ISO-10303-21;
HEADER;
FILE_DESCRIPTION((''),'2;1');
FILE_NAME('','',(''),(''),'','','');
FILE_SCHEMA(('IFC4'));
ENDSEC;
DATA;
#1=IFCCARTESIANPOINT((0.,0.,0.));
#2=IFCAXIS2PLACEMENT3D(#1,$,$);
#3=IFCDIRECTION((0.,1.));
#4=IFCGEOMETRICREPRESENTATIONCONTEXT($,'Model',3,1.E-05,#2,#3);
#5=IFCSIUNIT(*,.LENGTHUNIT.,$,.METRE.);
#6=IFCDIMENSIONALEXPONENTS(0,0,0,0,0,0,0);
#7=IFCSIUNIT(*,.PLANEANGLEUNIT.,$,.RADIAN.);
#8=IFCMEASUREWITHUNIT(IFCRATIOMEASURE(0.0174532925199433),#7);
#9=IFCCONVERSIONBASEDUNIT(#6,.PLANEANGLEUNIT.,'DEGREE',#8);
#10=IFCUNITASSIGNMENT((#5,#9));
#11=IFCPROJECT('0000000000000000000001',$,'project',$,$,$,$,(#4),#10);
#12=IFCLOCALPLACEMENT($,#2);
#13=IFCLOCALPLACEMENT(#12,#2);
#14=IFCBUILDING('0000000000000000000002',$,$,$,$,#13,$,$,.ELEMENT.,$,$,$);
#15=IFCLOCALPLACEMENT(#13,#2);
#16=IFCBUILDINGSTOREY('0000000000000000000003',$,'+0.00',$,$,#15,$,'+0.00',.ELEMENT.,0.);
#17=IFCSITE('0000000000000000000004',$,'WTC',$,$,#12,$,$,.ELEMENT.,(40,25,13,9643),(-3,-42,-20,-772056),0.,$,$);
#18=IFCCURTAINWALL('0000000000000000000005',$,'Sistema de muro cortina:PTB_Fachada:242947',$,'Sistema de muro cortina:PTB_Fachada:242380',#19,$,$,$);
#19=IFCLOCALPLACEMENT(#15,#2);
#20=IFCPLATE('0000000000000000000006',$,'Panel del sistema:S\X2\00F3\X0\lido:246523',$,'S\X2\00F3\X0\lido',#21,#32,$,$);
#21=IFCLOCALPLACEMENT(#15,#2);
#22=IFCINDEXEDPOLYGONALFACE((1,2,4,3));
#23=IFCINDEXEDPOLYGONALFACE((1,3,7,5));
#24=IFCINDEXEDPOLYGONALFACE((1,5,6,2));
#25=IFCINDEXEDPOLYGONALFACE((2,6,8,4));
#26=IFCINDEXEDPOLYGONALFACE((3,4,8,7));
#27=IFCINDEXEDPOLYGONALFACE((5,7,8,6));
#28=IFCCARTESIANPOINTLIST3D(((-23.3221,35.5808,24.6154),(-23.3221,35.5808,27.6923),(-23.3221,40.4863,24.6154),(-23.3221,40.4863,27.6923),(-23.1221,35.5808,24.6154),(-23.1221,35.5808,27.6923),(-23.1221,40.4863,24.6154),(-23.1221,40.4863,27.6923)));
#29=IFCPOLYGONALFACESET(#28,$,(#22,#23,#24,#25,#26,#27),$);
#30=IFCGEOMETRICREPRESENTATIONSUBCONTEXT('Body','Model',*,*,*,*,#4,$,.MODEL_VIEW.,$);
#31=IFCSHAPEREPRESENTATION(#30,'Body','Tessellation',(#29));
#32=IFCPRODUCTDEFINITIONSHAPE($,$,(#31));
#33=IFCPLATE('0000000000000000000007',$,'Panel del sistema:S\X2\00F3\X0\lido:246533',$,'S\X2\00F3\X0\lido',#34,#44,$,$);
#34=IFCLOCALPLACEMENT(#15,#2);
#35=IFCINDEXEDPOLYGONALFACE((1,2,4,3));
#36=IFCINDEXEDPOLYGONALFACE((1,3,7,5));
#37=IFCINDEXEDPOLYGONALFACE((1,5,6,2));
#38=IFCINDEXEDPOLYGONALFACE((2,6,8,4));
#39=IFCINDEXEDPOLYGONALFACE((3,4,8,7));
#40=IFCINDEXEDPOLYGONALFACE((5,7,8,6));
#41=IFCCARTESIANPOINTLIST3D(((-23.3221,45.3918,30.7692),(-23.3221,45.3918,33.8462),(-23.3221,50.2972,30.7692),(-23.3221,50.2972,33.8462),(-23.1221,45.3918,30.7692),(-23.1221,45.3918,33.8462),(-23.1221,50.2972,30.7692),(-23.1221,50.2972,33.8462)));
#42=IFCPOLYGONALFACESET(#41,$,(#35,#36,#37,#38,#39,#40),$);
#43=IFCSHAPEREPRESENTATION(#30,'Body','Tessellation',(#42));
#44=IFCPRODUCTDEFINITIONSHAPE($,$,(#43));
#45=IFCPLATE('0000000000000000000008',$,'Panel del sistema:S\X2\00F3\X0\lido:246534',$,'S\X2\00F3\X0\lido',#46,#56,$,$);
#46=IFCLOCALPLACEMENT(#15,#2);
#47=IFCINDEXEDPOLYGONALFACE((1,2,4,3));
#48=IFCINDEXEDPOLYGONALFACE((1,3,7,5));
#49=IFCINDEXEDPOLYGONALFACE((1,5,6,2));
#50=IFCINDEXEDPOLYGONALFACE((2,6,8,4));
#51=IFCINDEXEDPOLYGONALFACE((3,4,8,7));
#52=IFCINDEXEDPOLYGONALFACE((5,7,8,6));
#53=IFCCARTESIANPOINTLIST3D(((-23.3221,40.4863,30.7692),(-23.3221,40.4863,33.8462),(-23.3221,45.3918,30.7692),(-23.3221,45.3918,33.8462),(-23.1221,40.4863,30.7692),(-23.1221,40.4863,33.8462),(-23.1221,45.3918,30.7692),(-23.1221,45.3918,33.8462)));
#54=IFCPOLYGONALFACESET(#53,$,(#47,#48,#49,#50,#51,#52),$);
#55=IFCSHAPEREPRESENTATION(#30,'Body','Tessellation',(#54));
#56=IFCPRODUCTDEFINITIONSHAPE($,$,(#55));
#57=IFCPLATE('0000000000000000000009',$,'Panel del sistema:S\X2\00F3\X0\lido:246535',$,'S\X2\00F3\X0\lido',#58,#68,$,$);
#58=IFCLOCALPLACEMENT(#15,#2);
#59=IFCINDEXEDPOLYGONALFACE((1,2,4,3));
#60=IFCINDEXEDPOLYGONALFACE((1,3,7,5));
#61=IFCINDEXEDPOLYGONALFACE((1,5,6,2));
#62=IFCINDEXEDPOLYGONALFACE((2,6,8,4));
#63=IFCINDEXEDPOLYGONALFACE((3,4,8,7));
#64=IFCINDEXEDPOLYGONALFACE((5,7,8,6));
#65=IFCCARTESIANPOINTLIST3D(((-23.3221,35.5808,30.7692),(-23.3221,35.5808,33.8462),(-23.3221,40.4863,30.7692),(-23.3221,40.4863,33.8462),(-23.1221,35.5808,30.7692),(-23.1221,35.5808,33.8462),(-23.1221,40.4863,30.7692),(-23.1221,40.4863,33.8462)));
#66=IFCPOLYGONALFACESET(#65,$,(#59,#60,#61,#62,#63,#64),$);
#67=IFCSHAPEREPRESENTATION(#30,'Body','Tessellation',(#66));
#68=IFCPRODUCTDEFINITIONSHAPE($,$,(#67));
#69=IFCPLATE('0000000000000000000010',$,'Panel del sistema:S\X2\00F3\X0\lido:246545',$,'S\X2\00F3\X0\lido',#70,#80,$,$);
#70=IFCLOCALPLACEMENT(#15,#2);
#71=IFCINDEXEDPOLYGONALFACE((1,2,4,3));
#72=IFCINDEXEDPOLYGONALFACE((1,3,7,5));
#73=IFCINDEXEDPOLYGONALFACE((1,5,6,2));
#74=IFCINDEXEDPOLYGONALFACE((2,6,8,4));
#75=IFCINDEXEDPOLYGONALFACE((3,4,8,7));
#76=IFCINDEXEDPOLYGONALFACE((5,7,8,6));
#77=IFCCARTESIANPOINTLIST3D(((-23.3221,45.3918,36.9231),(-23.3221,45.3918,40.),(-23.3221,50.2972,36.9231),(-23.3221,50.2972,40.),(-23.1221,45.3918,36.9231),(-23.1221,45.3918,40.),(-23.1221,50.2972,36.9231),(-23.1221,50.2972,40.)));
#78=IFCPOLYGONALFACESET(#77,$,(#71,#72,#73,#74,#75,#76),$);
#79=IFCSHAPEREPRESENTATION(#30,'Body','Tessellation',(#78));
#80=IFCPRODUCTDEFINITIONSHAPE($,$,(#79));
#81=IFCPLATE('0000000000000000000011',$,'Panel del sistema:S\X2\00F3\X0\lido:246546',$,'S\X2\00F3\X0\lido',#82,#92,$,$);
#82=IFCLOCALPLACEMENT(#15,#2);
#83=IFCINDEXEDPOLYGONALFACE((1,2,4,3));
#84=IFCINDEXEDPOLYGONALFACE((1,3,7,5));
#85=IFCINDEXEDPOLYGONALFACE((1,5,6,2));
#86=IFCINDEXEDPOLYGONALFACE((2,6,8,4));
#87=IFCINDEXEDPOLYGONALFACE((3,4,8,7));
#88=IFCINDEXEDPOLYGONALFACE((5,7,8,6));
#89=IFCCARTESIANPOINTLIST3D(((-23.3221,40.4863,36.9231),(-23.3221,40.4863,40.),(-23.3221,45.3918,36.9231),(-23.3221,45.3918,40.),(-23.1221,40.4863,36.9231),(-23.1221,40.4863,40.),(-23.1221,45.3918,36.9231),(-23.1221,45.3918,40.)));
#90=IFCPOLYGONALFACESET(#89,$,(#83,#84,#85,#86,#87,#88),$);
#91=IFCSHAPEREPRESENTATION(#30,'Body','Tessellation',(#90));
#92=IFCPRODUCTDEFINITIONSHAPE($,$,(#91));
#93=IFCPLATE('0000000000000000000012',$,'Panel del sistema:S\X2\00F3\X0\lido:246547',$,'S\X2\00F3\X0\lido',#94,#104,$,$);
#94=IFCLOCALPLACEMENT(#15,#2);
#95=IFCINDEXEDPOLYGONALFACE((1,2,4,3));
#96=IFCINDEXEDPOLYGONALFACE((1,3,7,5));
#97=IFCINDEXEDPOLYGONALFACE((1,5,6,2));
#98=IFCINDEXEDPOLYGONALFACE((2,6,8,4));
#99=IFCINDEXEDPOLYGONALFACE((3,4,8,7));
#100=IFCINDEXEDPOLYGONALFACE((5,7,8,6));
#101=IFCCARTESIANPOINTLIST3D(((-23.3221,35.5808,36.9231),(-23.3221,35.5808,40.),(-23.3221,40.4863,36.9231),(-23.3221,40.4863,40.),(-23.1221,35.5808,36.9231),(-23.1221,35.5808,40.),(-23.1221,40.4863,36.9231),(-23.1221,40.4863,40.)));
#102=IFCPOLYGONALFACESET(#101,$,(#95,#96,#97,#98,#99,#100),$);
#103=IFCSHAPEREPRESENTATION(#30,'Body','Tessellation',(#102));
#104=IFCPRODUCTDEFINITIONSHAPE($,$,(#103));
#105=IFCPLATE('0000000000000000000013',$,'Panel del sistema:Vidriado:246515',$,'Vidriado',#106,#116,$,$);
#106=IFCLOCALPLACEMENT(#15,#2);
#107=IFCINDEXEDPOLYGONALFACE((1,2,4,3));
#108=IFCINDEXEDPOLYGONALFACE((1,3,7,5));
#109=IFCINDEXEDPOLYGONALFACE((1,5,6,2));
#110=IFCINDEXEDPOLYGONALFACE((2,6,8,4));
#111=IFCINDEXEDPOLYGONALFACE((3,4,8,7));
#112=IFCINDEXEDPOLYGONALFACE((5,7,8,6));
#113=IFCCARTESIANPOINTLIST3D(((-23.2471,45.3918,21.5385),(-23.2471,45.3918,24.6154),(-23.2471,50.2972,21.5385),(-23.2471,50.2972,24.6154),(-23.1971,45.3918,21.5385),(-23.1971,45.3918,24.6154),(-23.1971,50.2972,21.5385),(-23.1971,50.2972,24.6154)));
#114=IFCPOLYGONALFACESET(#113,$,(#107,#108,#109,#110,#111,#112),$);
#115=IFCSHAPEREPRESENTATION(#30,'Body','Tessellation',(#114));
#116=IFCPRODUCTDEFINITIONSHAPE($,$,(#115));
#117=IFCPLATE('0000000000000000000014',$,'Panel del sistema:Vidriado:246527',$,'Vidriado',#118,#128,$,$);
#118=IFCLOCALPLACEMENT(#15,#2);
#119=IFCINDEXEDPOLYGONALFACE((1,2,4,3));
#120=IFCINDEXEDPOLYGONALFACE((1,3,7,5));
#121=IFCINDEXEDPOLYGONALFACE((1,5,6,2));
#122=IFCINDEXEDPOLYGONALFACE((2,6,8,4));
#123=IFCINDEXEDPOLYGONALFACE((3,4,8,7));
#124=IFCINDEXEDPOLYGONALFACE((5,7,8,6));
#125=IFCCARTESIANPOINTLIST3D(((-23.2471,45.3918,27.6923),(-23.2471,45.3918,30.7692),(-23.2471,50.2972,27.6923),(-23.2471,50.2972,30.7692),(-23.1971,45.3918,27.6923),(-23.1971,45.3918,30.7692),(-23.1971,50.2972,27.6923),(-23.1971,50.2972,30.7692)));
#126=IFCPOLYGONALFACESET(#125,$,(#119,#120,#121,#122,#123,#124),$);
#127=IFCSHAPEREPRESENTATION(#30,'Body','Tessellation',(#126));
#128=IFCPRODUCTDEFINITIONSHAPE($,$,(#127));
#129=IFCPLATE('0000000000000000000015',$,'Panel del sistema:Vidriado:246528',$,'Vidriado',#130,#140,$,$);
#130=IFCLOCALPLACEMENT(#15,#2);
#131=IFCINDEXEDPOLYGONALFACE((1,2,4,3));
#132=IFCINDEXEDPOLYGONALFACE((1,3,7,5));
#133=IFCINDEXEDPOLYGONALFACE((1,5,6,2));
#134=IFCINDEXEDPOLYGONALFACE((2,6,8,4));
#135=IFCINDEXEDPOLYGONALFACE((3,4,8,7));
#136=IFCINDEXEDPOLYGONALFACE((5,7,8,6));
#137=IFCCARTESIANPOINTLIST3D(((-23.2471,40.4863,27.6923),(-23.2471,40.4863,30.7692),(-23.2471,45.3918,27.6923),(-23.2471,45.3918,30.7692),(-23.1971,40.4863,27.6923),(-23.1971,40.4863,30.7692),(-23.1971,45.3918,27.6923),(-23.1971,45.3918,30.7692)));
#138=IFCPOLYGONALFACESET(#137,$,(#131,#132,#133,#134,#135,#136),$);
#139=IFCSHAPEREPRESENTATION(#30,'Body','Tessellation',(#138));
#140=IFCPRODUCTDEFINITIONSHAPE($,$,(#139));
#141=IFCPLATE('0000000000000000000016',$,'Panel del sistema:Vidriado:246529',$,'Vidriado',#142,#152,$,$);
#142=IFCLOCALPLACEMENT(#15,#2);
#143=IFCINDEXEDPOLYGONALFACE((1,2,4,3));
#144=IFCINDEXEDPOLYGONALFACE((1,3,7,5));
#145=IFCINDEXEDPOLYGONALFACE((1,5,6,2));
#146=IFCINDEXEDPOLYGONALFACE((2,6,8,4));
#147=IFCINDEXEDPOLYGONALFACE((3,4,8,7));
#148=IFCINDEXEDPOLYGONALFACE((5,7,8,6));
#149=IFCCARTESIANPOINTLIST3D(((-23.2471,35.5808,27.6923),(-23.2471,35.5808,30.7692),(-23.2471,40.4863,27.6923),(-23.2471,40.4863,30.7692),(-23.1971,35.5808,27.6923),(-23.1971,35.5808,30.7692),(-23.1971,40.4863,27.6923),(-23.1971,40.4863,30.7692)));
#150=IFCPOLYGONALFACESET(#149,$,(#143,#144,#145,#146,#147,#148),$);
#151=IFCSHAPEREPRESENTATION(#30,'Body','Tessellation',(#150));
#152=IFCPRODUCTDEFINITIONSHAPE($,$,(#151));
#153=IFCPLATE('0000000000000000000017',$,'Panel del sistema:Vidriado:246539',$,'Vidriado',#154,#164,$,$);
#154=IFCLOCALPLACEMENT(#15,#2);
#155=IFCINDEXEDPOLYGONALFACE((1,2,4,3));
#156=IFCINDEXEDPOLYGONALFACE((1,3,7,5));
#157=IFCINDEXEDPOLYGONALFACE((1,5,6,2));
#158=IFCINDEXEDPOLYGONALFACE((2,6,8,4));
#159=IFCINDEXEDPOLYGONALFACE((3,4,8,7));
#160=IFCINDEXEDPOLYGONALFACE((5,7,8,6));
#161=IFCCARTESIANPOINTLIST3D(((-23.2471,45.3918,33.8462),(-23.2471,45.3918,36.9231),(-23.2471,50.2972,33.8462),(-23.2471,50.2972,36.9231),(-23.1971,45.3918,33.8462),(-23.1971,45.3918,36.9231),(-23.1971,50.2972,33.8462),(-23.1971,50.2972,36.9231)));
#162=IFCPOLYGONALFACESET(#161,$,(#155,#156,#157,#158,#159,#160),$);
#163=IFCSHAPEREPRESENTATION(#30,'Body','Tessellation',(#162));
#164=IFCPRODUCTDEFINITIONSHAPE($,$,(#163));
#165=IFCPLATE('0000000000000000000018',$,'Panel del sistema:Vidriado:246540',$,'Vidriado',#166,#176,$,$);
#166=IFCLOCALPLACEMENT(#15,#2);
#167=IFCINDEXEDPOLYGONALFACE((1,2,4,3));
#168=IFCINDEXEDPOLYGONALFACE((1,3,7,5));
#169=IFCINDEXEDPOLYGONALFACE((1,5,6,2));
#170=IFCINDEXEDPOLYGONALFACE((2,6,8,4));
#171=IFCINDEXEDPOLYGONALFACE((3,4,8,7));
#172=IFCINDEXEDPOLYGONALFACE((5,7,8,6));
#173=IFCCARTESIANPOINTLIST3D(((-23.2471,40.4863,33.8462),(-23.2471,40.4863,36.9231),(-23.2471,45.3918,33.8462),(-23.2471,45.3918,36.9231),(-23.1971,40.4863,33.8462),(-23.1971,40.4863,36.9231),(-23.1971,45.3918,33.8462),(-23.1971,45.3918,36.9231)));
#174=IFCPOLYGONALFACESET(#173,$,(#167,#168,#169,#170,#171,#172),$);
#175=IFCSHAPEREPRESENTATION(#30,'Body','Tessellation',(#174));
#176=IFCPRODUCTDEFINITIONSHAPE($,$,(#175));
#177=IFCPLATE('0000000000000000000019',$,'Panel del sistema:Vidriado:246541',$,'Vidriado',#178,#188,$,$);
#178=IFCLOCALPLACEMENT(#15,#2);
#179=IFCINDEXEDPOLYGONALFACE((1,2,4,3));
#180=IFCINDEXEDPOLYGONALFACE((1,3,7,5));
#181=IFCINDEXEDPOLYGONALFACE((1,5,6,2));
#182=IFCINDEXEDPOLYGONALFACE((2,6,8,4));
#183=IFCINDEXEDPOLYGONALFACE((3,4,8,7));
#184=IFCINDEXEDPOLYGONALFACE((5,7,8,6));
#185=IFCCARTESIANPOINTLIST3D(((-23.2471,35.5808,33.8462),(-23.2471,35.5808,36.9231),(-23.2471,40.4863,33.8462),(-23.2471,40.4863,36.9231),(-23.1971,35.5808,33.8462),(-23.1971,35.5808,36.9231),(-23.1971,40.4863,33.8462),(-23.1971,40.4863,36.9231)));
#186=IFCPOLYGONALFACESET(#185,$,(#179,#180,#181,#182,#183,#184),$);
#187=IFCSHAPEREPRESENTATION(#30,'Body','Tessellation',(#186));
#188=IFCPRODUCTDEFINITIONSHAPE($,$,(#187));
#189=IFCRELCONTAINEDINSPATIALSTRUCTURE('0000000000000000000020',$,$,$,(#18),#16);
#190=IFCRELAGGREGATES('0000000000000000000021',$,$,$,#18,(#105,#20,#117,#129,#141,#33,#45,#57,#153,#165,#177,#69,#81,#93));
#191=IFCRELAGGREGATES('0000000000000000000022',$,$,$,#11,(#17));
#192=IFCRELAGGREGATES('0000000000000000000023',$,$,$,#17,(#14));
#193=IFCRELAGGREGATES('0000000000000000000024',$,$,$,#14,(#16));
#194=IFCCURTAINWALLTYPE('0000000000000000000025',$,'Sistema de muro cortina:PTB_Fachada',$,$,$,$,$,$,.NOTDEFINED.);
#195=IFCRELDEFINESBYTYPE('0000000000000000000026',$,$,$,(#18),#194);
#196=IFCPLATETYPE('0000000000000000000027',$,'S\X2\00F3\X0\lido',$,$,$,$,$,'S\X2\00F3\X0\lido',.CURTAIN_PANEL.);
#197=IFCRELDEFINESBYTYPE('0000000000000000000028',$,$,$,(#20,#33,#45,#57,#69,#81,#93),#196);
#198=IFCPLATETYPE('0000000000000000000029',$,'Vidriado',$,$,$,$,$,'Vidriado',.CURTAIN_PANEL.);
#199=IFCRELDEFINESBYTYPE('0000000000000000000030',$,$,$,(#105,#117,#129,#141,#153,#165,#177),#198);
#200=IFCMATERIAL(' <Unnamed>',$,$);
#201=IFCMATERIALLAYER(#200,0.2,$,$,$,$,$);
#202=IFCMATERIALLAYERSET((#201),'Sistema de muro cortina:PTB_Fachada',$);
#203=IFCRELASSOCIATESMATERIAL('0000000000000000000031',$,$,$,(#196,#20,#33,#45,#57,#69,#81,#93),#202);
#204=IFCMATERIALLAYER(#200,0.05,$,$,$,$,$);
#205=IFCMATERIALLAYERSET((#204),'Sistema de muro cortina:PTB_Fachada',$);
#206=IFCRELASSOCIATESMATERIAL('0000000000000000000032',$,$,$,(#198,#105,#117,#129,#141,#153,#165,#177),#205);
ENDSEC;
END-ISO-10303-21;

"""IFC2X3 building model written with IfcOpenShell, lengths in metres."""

from ifc_helpers import new_model, entity, si_unit, converted_unit, direction, frame, origin, origin_2d_with_axis, place, context, subcontext, project, spatial, rectangle, extrude, source, transform, mapped, material, layer, layer_set, layer_usage, type_object, type_shapes, element, aggregate, save


model = new_model("IFC2X3")

# Units and contexts
model_context = context("Model", 3, precision=1e-05, world=origin(), true_north=direction((0.0, 1.0)))
body_context = subcontext(model_context, "Body", "Model", "MODEL_VIEW")
ifc_project = project(units=[si_unit("LENGTHUNIT", "METRE"), converted_unit("PLANEANGLEUNIT", "DEGREE", entity("IfcRatioMeasure", 0.0174532925199433), si_unit("PLANEANGLEUNIT", "RADIAN"), dimensions=[0, 0, 0, 0, 0, 0, 0])], contexts=[model_context])

# Site, building, storey
site_placement = place(None, origin())
site = spatial("IfcSite", under=ifc_project, at=site_placement, Name="WTC", CompositionType="ELEMENT", RefLatitude=(40, 25, 13, 9643), RefLongitude=(-3, -42, -20, -772056), RefElevation=0.0)
building_placement = place(site_placement, origin())
building = spatial("IfcBuilding", under=site, at=building_placement, CompositionType="ELEMENT")
storey_placement = place(building_placement, origin())
storey = spatial("IfcBuildingStorey", under=building, at=storey_placement, Name="+0.00", LongName="+0.00", CompositionType="ELEMENT", Elevation=0.0)

# Shared definitions
curtain_wall_type = type_object("IfcCurtainWallType", Name="Sistema de muro cortina:PTB_Fachada", PredefinedType="NOTDEFINED")
ifc_material = material(Name=" <Unnamed>")
ifc_layer_1 = layer(ifc_material, 0.2)
ifc_layer_set_1 = layer_set([ifc_layer_1], Name="Sistema de muro cortina:PTB_Fachada")

# Curtain wall, plates
ifc_layer_2 = layer(ifc_material, 0.05)
ifc_layer_set_2 = layer_set([ifc_layer_2], Name="Sistema de muro cortina:PTB_Fachada")
curtain_wall_1_placement = place(storey_placement, origin())
curtain_wall_1 = element("IfcCurtainWall", 1, at=curtain_wall_1_placement, inside=storey, type_object=curtain_wall_type, Name="Sistema de muro cortina:PTB_Fachada:242947", ObjectType="Sistema de muro cortina:PTB_Fachada:242380")
plate_type_1 = type_object("IfcPlateType", Name="Sólido", ElementType="Sólido", PredefinedType="CURTAIN_PANEL", material=ifc_layer_set_1)
shared_shape_1 = source(origin(), body_context, "Body", "SweptSolid", [
    extrude(rectangle(XDim=0.2, YDim=4.9055, at=origin_2d_with_axis()), frame((0.0, 0.0, 0.0), z_axis=(0.0, 0.0, 1.0), x_axis=(0.0, 1.0, 0.0)), (0.0, 0.0, 1.0), 3.0769),
])
type_shapes(plate_type_1, [shared_shape_1])
ifc_layer_usage_1 = layer_usage(ifc_layer_set_1, "AXIS3", "POSITIVE", 0.0)
plate_1_placement = place(curtain_wall_1_placement, frame((-23.2221, 38.0336, 24.6154), z_axis=(0.0, 0.0, 1.0), x_axis=(0.0, -1.0, 0.0)))
plate_1 = element("IfcPlate", 2, at=plate_1_placement, type_object=plate_type_1, material=ifc_layer_usage_1, Name="Panel del sistema:Sólido:246523", ObjectType="Sólido", context=body_context, shape_type="MappedRepresentation", body=[
    mapped(shared_shape_1, transform((0.0, 0.0, 0.0), scale=1.0)),
])
ifc_layer_usage_2 = layer_usage(ifc_layer_set_1, "AXIS3", "POSITIVE", 0.0)
plate_2_placement = place(curtain_wall_1_placement, frame((-23.2221, 47.8445, 30.7692), z_axis=(0.0, 0.0, 1.0), x_axis=(0.0, -1.0, 0.0)))
plate_2 = element("IfcPlate", 3, at=plate_2_placement, type_object=plate_type_1, material=ifc_layer_usage_2, Name="Panel del sistema:Sólido:246533", ObjectType="Sólido", context=body_context, shape_type="MappedRepresentation", body=[
    mapped(shared_shape_1, transform((0.0, 0.0, 0.0), scale=1.0)),
])
ifc_layer_usage_3 = layer_usage(ifc_layer_set_1, "AXIS3", "POSITIVE", 0.0)
plate_3_placement = place(curtain_wall_1_placement, frame((-23.2221, 42.939, 30.7692), z_axis=(0.0, 0.0, 1.0), x_axis=(0.0, -1.0, 0.0)))
plate_3 = element("IfcPlate", 4, at=plate_3_placement, type_object=plate_type_1, material=ifc_layer_usage_3, Name="Panel del sistema:Sólido:246534", ObjectType="Sólido", context=body_context, shape_type="MappedRepresentation", body=[
    mapped(shared_shape_1, transform((0.0, 0.0, 0.0), scale=1.0)),
])
ifc_layer_usage_4 = layer_usage(ifc_layer_set_1, "AXIS3", "POSITIVE", 0.0)
plate_4_placement = place(curtain_wall_1_placement, frame((-23.2221, 38.0336, 30.7692), z_axis=(0.0, 0.0, 1.0), x_axis=(0.0, -1.0, 0.0)))
plate_4 = element("IfcPlate", 5, at=plate_4_placement, type_object=plate_type_1, material=ifc_layer_usage_4, Name="Panel del sistema:Sólido:246535", ObjectType="Sólido", context=body_context, shape_type="MappedRepresentation", body=[
    mapped(shared_shape_1, transform((0.0, 0.0, 0.0), scale=1.0)),
])
ifc_layer_usage_5 = layer_usage(ifc_layer_set_1, "AXIS3", "POSITIVE", 0.0)
plate_5_placement = place(curtain_wall_1_placement, frame((-23.2221, 47.8445, 36.9231), z_axis=(0.0, 0.0, 1.0), x_axis=(0.0, -1.0, 0.0)))
plate_5 = element("IfcPlate", 6, at=plate_5_placement, type_object=plate_type_1, material=ifc_layer_usage_5, Name="Panel del sistema:Sólido:246545", ObjectType="Sólido", context=body_context, shape_type="MappedRepresentation", body=[
    mapped(shared_shape_1, transform((0.0, 0.0, 0.0), scale=1.0)),
])
ifc_layer_usage_6 = layer_usage(ifc_layer_set_1, "AXIS3", "POSITIVE", 0.0)
plate_6_placement = place(curtain_wall_1_placement, frame((-23.2221, 42.939, 36.9231), z_axis=(0.0, 0.0, 1.0), x_axis=(0.0, -1.0, 0.0)))
plate_6 = element("IfcPlate", 7, at=plate_6_placement, type_object=plate_type_1, material=ifc_layer_usage_6, Name="Panel del sistema:Sólido:246546", ObjectType="Sólido", context=body_context, shape_type="MappedRepresentation", body=[
    mapped(shared_shape_1, transform((0.0, 0.0, 0.0), scale=1.0)),
])
ifc_layer_usage_7 = layer_usage(ifc_layer_set_1, "AXIS3", "POSITIVE", 0.0)
plate_7_placement = place(curtain_wall_1_placement, frame((-23.2221, 38.0336, 36.9231), z_axis=(0.0, 0.0, 1.0), x_axis=(0.0, -1.0, 0.0)))
plate_7 = element("IfcPlate", 8, at=plate_7_placement, type_object=plate_type_1, material=ifc_layer_usage_7, Name="Panel del sistema:Sólido:246547", ObjectType="Sólido", context=body_context, shape_type="MappedRepresentation", body=[
    mapped(shared_shape_1, transform((0.0, 0.0, 0.0), scale=1.0)),
])
ifc_layer_usage_8 = layer_usage(ifc_layer_set_2, "AXIS3", "POSITIVE", 0.0)
plate_type_2 = type_object("IfcPlateType", Name="Vidriado", ElementType="Vidriado", PredefinedType="CURTAIN_PANEL", material=ifc_layer_set_2)
shared_shape_2 = source(origin(), body_context, "Body", "SweptSolid", [
    extrude(rectangle(XDim=0.05, YDim=4.9055, at=origin_2d_with_axis()), frame((0.0, 0.0, 0.0), z_axis=(0.0, 0.0, 1.0), x_axis=(0.0, 1.0, 0.0)), (0.0, 0.0, 1.0), 3.0769),
])
type_shapes(plate_type_2, [shared_shape_2])
plate_8_placement = place(curtain_wall_1_placement, frame((-23.2221, 47.8445, 21.5385), z_axis=(0.0, 0.0, 1.0), x_axis=(0.0, -1.0, 0.0)))
plate_8 = element("IfcPlate", 9, at=plate_8_placement, type_object=plate_type_2, material=ifc_layer_usage_8, Name="Panel del sistema:Vidriado:246515", ObjectType="Vidriado", context=body_context, shape_type="MappedRepresentation", body=[
    mapped(shared_shape_2, transform((0.0, 0.0, 0.0), scale=1.0)),
])
ifc_layer_usage_9 = layer_usage(ifc_layer_set_2, "AXIS3", "POSITIVE", 0.0)
plate_9_placement = place(curtain_wall_1_placement, frame((-23.2221, 47.8445, 27.6923), z_axis=(0.0, 0.0, 1.0), x_axis=(0.0, -1.0, 0.0)))
plate_9 = element("IfcPlate", 10, at=plate_9_placement, type_object=plate_type_2, material=ifc_layer_usage_9, Name="Panel del sistema:Vidriado:246527", ObjectType="Vidriado", context=body_context, shape_type="MappedRepresentation", body=[
    mapped(shared_shape_2, transform((0.0, 0.0, 0.0), scale=1.0)),
])
ifc_layer_usage_10 = layer_usage(ifc_layer_set_2, "AXIS3", "POSITIVE", 0.0)
plate_10_placement = place(curtain_wall_1_placement, frame((-23.2221, 42.939, 27.6923), z_axis=(0.0, 0.0, 1.0), x_axis=(0.0, -1.0, 0.0)))
plate_10 = element("IfcPlate", 11, at=plate_10_placement, type_object=plate_type_2, material=ifc_layer_usage_10, Name="Panel del sistema:Vidriado:246528", ObjectType="Vidriado", context=body_context, shape_type="MappedRepresentation", body=[
    mapped(shared_shape_2, transform((0.0, 0.0, 0.0), scale=1.0)),
])
ifc_layer_usage_11 = layer_usage(ifc_layer_set_2, "AXIS3", "POSITIVE", 0.0)
plate_11_placement = place(curtain_wall_1_placement, frame((-23.2221, 38.0336, 27.6923), z_axis=(0.0, 0.0, 1.0), x_axis=(0.0, -1.0, 0.0)))
plate_11 = element("IfcPlate", 12, at=plate_11_placement, type_object=plate_type_2, material=ifc_layer_usage_11, Name="Panel del sistema:Vidriado:246529", ObjectType="Vidriado", context=body_context, shape_type="MappedRepresentation", body=[
    mapped(shared_shape_2, transform((0.0, 0.0, 0.0), scale=1.0)),
])
ifc_layer_usage_12 = layer_usage(ifc_layer_set_2, "AXIS3", "POSITIVE", 0.0)
plate_12_placement = place(curtain_wall_1_placement, frame((-23.2221, 47.8445, 33.8462), z_axis=(0.0, 0.0, 1.0), x_axis=(0.0, -1.0, 0.0)))
plate_12 = element("IfcPlate", 13, at=plate_12_placement, type_object=plate_type_2, material=ifc_layer_usage_12, Name="Panel del sistema:Vidriado:246539", ObjectType="Vidriado", context=body_context, shape_type="MappedRepresentation", body=[
    mapped(shared_shape_2, transform((0.0, 0.0, 0.0), scale=1.0)),
])
ifc_layer_usage_13 = layer_usage(ifc_layer_set_2, "AXIS3", "POSITIVE", 0.0)
plate_13_placement = place(curtain_wall_1_placement, frame((-23.2221, 42.939, 33.8462), z_axis=(0.0, 0.0, 1.0), x_axis=(0.0, -1.0, 0.0)))
plate_13 = element("IfcPlate", 14, at=plate_13_placement, type_object=plate_type_2, material=ifc_layer_usage_13, Name="Panel del sistema:Vidriado:246540", ObjectType="Vidriado", context=body_context, shape_type="MappedRepresentation", body=[
    mapped(shared_shape_2, transform((0.0, 0.0, 0.0), scale=1.0)),
])
ifc_layer_usage_14 = layer_usage(ifc_layer_set_2, "AXIS3", "POSITIVE", 0.0)
plate_14_placement = place(curtain_wall_1_placement, frame((-23.2221, 38.0336, 33.8462), z_axis=(0.0, 0.0, 1.0), x_axis=(0.0, -1.0, 0.0)))
plate_14 = element("IfcPlate", 15, at=plate_14_placement, type_object=plate_type_2, material=ifc_layer_usage_14, Name="Panel del sistema:Vidriado:246541", ObjectType="Vidriado", context=body_context, shape_type="MappedRepresentation", body=[
    mapped(shared_shape_2, transform((0.0, 0.0, 0.0), scale=1.0)),
])
aggregate(curtain_wall_1, [plate_8, plate_1, plate_9, plate_10, plate_11, plate_2, plate_3, plate_4, plate_12, plate_13, plate_14, plate_5, plate_6, plate_7])

save(model, "model.ifc")
